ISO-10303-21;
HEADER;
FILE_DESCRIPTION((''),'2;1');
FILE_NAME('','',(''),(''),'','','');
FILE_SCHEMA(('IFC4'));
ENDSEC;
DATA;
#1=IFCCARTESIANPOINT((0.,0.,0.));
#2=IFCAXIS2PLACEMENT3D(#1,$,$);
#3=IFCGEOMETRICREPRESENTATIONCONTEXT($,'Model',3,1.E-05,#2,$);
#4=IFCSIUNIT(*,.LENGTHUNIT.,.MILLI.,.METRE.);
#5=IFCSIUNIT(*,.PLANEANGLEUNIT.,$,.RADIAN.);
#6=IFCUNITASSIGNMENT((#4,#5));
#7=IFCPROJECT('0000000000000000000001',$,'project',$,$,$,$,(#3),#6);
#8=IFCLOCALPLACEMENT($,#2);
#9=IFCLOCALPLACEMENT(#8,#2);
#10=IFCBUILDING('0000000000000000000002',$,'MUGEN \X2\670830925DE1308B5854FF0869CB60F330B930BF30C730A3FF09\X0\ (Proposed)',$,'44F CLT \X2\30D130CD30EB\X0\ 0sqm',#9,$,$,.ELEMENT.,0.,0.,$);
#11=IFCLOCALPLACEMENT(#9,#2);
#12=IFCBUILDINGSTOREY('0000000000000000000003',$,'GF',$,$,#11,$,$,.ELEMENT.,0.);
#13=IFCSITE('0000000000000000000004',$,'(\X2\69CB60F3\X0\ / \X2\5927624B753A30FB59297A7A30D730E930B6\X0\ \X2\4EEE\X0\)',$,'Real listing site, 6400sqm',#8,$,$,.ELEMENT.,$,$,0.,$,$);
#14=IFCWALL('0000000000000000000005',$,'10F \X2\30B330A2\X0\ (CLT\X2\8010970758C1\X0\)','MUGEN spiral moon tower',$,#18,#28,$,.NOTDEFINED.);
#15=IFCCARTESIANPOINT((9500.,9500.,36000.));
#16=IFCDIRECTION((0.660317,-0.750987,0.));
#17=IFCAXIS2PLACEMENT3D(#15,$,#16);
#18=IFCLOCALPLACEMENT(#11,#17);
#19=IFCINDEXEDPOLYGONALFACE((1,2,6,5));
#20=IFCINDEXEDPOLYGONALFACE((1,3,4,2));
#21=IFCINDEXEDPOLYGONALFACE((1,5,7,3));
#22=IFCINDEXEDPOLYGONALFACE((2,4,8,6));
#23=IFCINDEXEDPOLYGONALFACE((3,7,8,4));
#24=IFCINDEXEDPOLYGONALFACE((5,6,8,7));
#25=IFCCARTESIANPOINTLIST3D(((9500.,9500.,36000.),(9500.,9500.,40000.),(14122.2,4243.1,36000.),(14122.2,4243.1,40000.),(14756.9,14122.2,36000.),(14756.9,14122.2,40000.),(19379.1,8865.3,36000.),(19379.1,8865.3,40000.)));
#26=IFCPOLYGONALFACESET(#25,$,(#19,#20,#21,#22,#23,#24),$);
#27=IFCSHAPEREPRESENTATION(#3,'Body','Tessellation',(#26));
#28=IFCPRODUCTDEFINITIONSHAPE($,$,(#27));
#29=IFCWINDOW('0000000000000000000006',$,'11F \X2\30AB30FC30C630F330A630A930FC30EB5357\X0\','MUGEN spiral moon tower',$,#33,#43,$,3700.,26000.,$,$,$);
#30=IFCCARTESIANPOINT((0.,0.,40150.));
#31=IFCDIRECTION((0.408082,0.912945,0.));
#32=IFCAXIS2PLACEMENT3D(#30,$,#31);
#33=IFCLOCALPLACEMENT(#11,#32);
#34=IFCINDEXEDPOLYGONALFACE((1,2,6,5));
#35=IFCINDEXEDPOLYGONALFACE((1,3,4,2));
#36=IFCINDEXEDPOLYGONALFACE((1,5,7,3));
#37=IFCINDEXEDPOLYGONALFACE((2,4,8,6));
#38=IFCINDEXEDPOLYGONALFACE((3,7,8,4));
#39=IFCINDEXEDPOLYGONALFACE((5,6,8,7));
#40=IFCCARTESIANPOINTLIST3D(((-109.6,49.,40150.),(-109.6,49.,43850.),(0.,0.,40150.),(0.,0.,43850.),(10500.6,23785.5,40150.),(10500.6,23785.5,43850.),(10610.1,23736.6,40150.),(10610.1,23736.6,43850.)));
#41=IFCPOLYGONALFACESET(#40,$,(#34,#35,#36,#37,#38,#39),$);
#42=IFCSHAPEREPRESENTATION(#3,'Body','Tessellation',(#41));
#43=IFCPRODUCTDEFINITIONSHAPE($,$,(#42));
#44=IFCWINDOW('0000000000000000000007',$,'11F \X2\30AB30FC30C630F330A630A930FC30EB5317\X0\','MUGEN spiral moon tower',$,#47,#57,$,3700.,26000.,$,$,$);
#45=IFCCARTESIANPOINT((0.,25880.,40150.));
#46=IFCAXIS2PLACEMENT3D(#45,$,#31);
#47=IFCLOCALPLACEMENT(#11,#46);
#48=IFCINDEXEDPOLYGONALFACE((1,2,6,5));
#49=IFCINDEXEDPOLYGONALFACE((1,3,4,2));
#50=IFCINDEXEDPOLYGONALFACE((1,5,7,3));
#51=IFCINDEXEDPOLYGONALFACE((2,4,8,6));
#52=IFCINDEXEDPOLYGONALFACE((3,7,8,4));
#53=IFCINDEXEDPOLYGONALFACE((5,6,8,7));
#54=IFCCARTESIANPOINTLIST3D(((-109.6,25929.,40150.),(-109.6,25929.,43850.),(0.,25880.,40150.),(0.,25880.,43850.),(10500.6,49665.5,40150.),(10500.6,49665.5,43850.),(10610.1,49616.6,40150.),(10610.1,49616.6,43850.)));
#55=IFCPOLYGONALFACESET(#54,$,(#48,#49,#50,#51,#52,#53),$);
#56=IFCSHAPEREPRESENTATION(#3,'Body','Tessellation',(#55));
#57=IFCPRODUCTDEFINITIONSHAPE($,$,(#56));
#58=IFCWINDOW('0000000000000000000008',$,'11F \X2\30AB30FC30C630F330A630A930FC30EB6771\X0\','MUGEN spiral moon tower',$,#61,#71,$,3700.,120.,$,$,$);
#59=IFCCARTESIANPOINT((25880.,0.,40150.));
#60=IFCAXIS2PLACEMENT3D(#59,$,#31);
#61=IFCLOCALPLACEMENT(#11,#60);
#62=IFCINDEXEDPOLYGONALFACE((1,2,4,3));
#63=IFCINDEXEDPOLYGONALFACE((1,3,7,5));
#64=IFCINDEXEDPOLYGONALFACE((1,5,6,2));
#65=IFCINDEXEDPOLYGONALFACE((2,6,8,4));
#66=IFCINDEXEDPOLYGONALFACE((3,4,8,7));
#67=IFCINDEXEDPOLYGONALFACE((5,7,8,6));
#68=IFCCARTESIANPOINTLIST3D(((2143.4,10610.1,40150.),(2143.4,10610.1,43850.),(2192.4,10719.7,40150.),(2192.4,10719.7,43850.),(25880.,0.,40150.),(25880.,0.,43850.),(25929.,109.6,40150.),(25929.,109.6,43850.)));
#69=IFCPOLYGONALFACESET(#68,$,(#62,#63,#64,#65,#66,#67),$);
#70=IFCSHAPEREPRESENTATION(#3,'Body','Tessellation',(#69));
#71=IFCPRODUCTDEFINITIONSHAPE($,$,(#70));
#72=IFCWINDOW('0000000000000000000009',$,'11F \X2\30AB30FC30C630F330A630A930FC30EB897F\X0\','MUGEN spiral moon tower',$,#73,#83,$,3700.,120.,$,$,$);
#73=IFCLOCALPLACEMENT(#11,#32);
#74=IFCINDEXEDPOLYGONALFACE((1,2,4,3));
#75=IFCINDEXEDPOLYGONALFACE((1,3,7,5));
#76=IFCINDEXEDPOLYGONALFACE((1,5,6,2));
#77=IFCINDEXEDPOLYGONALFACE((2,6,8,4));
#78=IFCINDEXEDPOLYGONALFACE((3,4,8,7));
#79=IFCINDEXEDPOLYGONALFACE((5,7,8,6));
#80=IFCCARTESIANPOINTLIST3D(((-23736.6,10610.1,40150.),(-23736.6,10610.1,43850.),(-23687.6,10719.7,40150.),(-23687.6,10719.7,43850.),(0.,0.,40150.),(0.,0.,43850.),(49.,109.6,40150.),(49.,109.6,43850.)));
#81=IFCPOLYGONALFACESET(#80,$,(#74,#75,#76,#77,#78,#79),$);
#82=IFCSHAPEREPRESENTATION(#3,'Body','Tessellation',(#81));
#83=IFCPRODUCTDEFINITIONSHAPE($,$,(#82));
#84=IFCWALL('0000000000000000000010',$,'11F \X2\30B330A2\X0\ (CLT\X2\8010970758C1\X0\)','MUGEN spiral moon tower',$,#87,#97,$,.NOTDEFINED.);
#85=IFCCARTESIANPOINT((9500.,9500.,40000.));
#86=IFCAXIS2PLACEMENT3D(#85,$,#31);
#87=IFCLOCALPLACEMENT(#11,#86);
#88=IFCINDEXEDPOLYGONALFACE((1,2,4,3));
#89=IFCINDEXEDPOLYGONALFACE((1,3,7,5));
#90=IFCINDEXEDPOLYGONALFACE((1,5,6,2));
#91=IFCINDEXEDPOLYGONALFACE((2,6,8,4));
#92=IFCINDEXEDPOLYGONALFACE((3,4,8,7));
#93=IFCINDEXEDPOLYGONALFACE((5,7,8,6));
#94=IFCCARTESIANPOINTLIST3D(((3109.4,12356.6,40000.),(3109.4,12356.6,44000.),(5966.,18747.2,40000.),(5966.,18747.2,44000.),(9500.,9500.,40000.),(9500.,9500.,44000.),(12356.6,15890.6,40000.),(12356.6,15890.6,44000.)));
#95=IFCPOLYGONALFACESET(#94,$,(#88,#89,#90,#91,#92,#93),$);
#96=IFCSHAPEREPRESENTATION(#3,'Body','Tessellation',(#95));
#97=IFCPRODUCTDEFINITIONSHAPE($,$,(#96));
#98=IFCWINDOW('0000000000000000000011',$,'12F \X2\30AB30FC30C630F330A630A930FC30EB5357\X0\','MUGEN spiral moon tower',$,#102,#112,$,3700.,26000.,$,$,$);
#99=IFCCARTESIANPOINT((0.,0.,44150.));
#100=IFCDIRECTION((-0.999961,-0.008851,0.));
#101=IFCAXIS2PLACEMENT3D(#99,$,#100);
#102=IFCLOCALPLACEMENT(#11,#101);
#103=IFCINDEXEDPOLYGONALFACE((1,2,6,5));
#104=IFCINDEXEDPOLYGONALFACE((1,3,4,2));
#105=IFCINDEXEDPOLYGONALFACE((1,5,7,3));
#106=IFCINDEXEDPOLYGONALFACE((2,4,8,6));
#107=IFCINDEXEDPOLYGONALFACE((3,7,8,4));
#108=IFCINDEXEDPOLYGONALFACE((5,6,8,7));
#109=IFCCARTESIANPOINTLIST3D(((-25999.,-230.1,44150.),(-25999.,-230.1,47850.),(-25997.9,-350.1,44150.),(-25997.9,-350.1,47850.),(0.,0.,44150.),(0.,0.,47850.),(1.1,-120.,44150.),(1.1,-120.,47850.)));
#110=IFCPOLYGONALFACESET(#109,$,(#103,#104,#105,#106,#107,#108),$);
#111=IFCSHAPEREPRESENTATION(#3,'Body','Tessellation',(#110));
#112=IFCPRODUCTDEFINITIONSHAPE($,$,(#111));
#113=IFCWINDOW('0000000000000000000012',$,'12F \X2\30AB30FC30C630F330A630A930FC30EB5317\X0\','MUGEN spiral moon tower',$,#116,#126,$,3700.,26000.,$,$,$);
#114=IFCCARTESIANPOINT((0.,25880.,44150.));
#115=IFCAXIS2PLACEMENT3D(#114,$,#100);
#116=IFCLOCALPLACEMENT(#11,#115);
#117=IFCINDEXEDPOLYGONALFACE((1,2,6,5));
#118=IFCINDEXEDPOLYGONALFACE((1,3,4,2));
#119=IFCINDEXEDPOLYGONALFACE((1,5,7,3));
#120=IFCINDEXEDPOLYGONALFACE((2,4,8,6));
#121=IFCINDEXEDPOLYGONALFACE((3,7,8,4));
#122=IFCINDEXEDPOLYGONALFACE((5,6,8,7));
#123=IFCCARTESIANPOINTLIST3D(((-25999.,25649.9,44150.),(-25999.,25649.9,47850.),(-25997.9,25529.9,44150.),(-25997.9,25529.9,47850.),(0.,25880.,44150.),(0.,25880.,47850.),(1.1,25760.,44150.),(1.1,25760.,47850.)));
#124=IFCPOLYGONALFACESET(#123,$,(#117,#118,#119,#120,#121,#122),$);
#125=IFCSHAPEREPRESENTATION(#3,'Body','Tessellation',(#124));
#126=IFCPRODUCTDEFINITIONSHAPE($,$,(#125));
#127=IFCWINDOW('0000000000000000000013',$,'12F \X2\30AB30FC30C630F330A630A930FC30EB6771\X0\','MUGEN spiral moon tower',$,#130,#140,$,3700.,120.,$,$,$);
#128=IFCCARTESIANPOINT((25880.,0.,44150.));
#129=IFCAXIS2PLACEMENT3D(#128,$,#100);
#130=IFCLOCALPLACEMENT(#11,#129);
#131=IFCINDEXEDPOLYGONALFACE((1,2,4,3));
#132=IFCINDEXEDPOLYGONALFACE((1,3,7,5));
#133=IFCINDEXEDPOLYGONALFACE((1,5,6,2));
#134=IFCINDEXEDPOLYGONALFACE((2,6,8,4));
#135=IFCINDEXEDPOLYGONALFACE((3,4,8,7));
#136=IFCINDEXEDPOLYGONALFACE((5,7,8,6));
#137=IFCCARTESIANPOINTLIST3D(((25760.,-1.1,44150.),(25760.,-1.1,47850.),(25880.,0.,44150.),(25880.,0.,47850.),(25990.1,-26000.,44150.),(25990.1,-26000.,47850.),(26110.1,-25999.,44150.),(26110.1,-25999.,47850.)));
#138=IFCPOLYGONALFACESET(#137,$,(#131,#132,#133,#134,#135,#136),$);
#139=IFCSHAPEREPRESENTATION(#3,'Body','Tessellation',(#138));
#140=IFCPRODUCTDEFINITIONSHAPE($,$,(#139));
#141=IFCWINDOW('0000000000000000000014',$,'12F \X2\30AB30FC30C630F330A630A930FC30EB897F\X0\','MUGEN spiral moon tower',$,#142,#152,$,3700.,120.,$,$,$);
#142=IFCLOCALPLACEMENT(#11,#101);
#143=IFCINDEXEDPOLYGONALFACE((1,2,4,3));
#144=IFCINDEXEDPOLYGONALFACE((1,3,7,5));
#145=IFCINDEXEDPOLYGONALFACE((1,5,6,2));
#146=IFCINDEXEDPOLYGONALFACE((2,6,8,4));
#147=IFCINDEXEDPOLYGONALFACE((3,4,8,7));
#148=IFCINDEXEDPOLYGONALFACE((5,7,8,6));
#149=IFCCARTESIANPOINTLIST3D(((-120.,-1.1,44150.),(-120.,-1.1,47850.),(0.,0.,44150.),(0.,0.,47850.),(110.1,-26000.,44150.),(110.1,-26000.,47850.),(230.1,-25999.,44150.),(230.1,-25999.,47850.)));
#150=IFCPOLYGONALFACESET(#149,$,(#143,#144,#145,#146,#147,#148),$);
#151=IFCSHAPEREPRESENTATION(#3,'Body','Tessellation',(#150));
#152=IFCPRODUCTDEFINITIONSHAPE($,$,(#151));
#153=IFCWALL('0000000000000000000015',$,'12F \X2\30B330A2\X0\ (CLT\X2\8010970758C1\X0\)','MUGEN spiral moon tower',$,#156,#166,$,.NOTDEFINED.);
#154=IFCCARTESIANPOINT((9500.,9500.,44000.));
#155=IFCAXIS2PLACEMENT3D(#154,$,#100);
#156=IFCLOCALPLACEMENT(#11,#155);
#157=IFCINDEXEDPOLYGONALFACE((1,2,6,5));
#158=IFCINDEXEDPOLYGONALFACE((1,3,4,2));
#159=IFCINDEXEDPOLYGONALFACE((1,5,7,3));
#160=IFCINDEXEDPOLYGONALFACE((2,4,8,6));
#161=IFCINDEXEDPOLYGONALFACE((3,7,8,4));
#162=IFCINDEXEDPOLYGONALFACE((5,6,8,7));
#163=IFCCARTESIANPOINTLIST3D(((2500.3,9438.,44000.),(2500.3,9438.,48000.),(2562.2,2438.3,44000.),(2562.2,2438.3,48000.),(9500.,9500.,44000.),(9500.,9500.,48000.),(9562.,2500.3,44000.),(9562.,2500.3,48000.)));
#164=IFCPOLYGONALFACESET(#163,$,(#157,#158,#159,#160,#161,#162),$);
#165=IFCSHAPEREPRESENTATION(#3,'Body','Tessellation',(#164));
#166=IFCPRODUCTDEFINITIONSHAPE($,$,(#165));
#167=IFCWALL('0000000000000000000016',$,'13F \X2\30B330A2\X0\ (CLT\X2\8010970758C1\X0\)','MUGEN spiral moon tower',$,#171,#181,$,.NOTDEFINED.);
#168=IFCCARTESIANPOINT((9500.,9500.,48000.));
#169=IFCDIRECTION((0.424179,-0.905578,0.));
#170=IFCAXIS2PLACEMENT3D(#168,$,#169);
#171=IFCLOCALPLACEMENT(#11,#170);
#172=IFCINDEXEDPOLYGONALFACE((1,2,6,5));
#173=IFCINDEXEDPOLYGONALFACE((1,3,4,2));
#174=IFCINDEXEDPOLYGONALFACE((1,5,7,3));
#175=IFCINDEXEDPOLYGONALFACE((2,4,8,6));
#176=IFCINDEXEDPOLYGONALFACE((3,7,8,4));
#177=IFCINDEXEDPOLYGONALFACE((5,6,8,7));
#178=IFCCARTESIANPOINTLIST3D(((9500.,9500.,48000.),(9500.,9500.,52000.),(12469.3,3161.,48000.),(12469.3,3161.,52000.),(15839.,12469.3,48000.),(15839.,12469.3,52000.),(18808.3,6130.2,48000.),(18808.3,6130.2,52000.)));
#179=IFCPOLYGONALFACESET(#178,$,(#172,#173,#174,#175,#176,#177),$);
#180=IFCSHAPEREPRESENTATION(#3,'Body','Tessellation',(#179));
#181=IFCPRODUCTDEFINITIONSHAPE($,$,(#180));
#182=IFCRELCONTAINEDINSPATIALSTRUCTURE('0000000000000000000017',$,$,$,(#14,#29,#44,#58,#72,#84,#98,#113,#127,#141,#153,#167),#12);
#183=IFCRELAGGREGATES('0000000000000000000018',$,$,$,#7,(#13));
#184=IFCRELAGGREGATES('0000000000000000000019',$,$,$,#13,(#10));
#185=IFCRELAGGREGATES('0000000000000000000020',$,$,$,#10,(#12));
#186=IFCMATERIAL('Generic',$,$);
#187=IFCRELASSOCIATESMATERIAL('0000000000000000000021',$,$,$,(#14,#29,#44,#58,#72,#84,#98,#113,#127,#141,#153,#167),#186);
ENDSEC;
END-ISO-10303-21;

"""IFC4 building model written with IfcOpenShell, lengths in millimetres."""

from ifc_helpers import new_model, si_unit, frame, frame_2d, origin, place, context, project, spatial, rectangle, extrude, material, element, save


model = new_model("IFC4")

# Units and contexts
model_context = context("Model", 3, precision=1e-05, world=origin())
ifc_project = project(units=[si_unit("LENGTHUNIT", "METRE", prefix="MILLI"), si_unit("PLANEANGLEUNIT", "RADIAN")], contexts=[model_context])

# Site, building, storey
site_placement = place(None, origin())
site = spatial("IfcSite", under=ifc_project, at=site_placement, Name="(構想 / 大手町・天空プラザ 仮)", ObjectType="Real listing site, 6400sqm", CompositionType="ELEMENT", RefElevation=0.0)
building_placement = place(site_placement, origin())
building = spatial("IfcBuilding", under=site, at=building_placement, Name="MUGEN 月を巡る塔（構想スタディ） (Proposed)", ObjectType="44F CLT パネル 0sqm", CompositionType="ELEMENT", ElevationOfRefHeight=0.0, ElevationOfTerrain=0.0)
storey_placement = place(building_placement, origin())
storey = spatial("IfcBuildingStorey", under=building, at=storey_placement, Name="GF", CompositionType="ELEMENT", Elevation=0.0)

# Shared definitions
ifc_material = material(Name="Generic")

# Wall
wall_1_placement = place(storey_placement, frame((9500.0, 9500.0, 36000.0), x_axis=(0.660317, -0.750987, 0.0)))
element("IfcWall", 1, at=wall_1_placement, inside=storey, material=ifc_material, Name="10F コア (CLT耐震壁)", Description="MUGEN spiral moon tower", PredefinedType="NOTDEFINED", context=model_context, shape_type="SweptSolid", body=[
    extrude(rectangle(XDim=7000.0, YDim=7000.0, at=frame_2d((3500.0, 3500.0))), frame((9500.0, 9500.0, 36000.0), x_axis=(0.660317, -0.750987, 0.0)), (0.0, 0.0, 1.0), 4000.0),
])

# Windows
window_1_placement = place(storey_placement, frame((0.0, 0.0, 40150.0), x_axis=(0.408082, 0.912945, 0.0)))
element("IfcWindow", 2, at=window_1_placement, inside=storey, material=ifc_material, Name="11F カーテンウォール南", Description="MUGEN spiral moon tower", OverallHeight=3700.0, OverallWidth=26000.0, context=model_context, shape_type="SweptSolid", body=[
    extrude(rectangle(XDim=26000.0, YDim=120.0, at=frame_2d((13000.0, 60.0))), frame((0.0, 0.0, 40150.0), x_axis=(0.408082, 0.912945, 0.0)), (0.0, 0.0, 1.0), 3700.0),
])
window_2_placement = place(storey_placement, frame((0.0, 25880.0, 40150.0), x_axis=(0.408082, 0.912945, 0.0)))
element("IfcWindow", 3, at=window_2_placement, inside=storey, material=ifc_material, Name="11F カーテンウォール北", Description="MUGEN spiral moon tower", OverallHeight=3700.0, OverallWidth=26000.0, context=model_context, shape_type="SweptSolid", body=[
    extrude(rectangle(XDim=26000.0, YDim=120.0, at=frame_2d((13000.0, 60.0))), frame((0.0, 25880.0, 40150.0), x_axis=(0.408082, 0.912945, 0.0)), (0.0, 0.0, 1.0), 3700.0),
])
window_3_placement = place(storey_placement, frame((25880.0, 0.0, 40150.0), x_axis=(0.408082, 0.912945, 0.0)))
element("IfcWindow", 4, at=window_3_placement, inside=storey, material=ifc_material, Name="11F カーテンウォール東", Description="MUGEN spiral moon tower", OverallHeight=3700.0, OverallWidth=120.0, context=model_context, shape_type="SweptSolid", body=[
    extrude(rectangle(XDim=120.0, YDim=26000.0, at=frame_2d((60.0, 13000.0))), frame((25880.0, 0.0, 40150.0), x_axis=(0.408082, 0.912945, 0.0)), (0.0, 0.0, 1.0), 3700.0),
])
window_4_placement = place(storey_placement, frame((0.0, 0.0, 40150.0), x_axis=(0.408082, 0.912945, 0.0)))
element("IfcWindow", 5, at=window_4_placement, inside=storey, material=ifc_material, Name="11F カーテンウォール西", Description="MUGEN spiral moon tower", OverallHeight=3700.0, OverallWidth=120.0, context=model_context, shape_type="SweptSolid", body=[
    extrude(rectangle(XDim=120.0, YDim=26000.0, at=frame_2d((60.0, 13000.0))), frame((0.0, 0.0, 40150.0), x_axis=(0.408082, 0.912945, 0.0)), (0.0, 0.0, 1.0), 3700.0),
])

# Wall
wall_2_placement = place(storey_placement, frame((9500.0, 9500.0, 40000.0), x_axis=(0.408082, 0.912945, 0.0)))
element("IfcWall", 6, at=wall_2_placement, inside=storey, material=ifc_material, Name="11F コア (CLT耐震壁)", Description="MUGEN spiral moon tower", PredefinedType="NOTDEFINED", context=model_context, shape_type="SweptSolid", body=[
    extrude(rectangle(XDim=7000.0, YDim=7000.0, at=frame_2d((3500.0, 3500.0))), frame((9500.0, 9500.0, 40000.0), x_axis=(0.408082, 0.912945, 0.0)), (0.0, 0.0, 1.0), 4000.0),
])

# Windows
window_5_placement = place(storey_placement, frame((0.0, 0.0, 44150.0), x_axis=(-0.999961, -0.008851, 0.0)))
element("IfcWindow", 7, at=window_5_placement, inside=storey, material=ifc_material, Name="12F カーテンウォール南", Description="MUGEN spiral moon tower", OverallHeight=3700.0, OverallWidth=26000.0, context=model_context, shape_type="SweptSolid", body=[
    extrude(rectangle(XDim=26000.0, YDim=120.0, at=frame_2d((13000.0, 60.0))), frame((0.0, 0.0, 44150.0), x_axis=(-0.999961, -0.008851, 0.0)), (0.0, 0.0, 1.0), 3700.0),
])
window_6_placement = place(storey_placement, frame((0.0, 25880.0, 44150.0), x_axis=(-0.999961, -0.008851, 0.0)))
element("IfcWindow", 8, at=window_6_placement, inside=storey, material=ifc_material, Name="12F カーテンウォール北", Description="MUGEN spiral moon tower", OverallHeight=3700.0, OverallWidth=26000.0, context=model_context, shape_type="SweptSolid", body=[
    extrude(rectangle(XDim=26000.0, YDim=120.0, at=frame_2d((13000.0, 60.0))), frame((0.0, 25880.0, 44150.0), x_axis=(-0.999961, -0.008851, 0.0)), (0.0, 0.0, 1.0), 3700.0),
])
window_7_placement = place(storey_placement, frame((25880.0, 0.0, 44150.0), x_axis=(-0.999961, -0.008851, 0.0)))
element("IfcWindow", 9, at=window_7_placement, inside=storey, material=ifc_material, Name="12F カーテンウォール東", Description="MUGEN spiral moon tower", OverallHeight=3700.0, OverallWidth=120.0, context=model_context, shape_type="SweptSolid", body=[
    extrude(rectangle(XDim=120.0, YDim=26000.0, at=frame_2d((60.0, 13000.0))), frame((25880.0, 0.0, 44150.0), x_axis=(-0.999961, -0.008851, 0.0)), (0.0, 0.0, 1.0), 3700.0),
])
window_8_placement = place(storey_placement, frame((0.0, 0.0, 44150.0), x_axis=(-0.999961, -0.008851, 0.0)))
element("IfcWindow", 10, at=window_8_placement, inside=storey, material=ifc_material, Name="12F カーテンウォール西", Description="MUGEN spiral moon tower", OverallHeight=3700.0, OverallWidth=120.0, context=model_context, shape_type="SweptSolid", body=[
    extrude(rectangle(XDim=120.0, YDim=26000.0, at=frame_2d((60.0, 13000.0))), frame((0.0, 0.0, 44150.0), x_axis=(-0.999961, -0.008851, 0.0)), (0.0, 0.0, 1.0), 3700.0),
])

# Walls
wall_3_placement = place(storey_placement, frame((9500.0, 9500.0, 44000.0), x_axis=(-0.999961, -0.008851, 0.0)))
element("IfcWall", 11, at=wall_3_placement, inside=storey, material=ifc_material, Name="12F コア (CLT耐震壁)", Description="MUGEN spiral moon tower", PredefinedType="NOTDEFINED", context=model_context, shape_type="SweptSolid", body=[
    extrude(rectangle(XDim=7000.0, YDim=7000.0, at=frame_2d((3500.0, 3500.0))), frame((9500.0, 9500.0, 44000.0), x_axis=(-0.999961, -0.008851, 0.0)), (0.0, 0.0, 1.0), 4000.0),
])
wall_4_placement = place(storey_placement, frame((9500.0, 9500.0, 48000.0), x_axis=(0.424179, -0.905578, 0.0)))
element("IfcWall", 12, at=wall_4_placement, inside=storey, material=ifc_material, Name="13F コア (CLT耐震壁)", Description="MUGEN spiral moon tower", PredefinedType="NOTDEFINED", context=model_context, shape_type="SweptSolid", body=[
    extrude(rectangle(XDim=7000.0, YDim=7000.0, at=frame_2d((3500.0, 3500.0))), frame((9500.0, 9500.0, 48000.0), x_axis=(0.424179, -0.905578, 0.0)), (0.0, 0.0, 1.0), 4000.0),
])

save(model, "model.ifc")
